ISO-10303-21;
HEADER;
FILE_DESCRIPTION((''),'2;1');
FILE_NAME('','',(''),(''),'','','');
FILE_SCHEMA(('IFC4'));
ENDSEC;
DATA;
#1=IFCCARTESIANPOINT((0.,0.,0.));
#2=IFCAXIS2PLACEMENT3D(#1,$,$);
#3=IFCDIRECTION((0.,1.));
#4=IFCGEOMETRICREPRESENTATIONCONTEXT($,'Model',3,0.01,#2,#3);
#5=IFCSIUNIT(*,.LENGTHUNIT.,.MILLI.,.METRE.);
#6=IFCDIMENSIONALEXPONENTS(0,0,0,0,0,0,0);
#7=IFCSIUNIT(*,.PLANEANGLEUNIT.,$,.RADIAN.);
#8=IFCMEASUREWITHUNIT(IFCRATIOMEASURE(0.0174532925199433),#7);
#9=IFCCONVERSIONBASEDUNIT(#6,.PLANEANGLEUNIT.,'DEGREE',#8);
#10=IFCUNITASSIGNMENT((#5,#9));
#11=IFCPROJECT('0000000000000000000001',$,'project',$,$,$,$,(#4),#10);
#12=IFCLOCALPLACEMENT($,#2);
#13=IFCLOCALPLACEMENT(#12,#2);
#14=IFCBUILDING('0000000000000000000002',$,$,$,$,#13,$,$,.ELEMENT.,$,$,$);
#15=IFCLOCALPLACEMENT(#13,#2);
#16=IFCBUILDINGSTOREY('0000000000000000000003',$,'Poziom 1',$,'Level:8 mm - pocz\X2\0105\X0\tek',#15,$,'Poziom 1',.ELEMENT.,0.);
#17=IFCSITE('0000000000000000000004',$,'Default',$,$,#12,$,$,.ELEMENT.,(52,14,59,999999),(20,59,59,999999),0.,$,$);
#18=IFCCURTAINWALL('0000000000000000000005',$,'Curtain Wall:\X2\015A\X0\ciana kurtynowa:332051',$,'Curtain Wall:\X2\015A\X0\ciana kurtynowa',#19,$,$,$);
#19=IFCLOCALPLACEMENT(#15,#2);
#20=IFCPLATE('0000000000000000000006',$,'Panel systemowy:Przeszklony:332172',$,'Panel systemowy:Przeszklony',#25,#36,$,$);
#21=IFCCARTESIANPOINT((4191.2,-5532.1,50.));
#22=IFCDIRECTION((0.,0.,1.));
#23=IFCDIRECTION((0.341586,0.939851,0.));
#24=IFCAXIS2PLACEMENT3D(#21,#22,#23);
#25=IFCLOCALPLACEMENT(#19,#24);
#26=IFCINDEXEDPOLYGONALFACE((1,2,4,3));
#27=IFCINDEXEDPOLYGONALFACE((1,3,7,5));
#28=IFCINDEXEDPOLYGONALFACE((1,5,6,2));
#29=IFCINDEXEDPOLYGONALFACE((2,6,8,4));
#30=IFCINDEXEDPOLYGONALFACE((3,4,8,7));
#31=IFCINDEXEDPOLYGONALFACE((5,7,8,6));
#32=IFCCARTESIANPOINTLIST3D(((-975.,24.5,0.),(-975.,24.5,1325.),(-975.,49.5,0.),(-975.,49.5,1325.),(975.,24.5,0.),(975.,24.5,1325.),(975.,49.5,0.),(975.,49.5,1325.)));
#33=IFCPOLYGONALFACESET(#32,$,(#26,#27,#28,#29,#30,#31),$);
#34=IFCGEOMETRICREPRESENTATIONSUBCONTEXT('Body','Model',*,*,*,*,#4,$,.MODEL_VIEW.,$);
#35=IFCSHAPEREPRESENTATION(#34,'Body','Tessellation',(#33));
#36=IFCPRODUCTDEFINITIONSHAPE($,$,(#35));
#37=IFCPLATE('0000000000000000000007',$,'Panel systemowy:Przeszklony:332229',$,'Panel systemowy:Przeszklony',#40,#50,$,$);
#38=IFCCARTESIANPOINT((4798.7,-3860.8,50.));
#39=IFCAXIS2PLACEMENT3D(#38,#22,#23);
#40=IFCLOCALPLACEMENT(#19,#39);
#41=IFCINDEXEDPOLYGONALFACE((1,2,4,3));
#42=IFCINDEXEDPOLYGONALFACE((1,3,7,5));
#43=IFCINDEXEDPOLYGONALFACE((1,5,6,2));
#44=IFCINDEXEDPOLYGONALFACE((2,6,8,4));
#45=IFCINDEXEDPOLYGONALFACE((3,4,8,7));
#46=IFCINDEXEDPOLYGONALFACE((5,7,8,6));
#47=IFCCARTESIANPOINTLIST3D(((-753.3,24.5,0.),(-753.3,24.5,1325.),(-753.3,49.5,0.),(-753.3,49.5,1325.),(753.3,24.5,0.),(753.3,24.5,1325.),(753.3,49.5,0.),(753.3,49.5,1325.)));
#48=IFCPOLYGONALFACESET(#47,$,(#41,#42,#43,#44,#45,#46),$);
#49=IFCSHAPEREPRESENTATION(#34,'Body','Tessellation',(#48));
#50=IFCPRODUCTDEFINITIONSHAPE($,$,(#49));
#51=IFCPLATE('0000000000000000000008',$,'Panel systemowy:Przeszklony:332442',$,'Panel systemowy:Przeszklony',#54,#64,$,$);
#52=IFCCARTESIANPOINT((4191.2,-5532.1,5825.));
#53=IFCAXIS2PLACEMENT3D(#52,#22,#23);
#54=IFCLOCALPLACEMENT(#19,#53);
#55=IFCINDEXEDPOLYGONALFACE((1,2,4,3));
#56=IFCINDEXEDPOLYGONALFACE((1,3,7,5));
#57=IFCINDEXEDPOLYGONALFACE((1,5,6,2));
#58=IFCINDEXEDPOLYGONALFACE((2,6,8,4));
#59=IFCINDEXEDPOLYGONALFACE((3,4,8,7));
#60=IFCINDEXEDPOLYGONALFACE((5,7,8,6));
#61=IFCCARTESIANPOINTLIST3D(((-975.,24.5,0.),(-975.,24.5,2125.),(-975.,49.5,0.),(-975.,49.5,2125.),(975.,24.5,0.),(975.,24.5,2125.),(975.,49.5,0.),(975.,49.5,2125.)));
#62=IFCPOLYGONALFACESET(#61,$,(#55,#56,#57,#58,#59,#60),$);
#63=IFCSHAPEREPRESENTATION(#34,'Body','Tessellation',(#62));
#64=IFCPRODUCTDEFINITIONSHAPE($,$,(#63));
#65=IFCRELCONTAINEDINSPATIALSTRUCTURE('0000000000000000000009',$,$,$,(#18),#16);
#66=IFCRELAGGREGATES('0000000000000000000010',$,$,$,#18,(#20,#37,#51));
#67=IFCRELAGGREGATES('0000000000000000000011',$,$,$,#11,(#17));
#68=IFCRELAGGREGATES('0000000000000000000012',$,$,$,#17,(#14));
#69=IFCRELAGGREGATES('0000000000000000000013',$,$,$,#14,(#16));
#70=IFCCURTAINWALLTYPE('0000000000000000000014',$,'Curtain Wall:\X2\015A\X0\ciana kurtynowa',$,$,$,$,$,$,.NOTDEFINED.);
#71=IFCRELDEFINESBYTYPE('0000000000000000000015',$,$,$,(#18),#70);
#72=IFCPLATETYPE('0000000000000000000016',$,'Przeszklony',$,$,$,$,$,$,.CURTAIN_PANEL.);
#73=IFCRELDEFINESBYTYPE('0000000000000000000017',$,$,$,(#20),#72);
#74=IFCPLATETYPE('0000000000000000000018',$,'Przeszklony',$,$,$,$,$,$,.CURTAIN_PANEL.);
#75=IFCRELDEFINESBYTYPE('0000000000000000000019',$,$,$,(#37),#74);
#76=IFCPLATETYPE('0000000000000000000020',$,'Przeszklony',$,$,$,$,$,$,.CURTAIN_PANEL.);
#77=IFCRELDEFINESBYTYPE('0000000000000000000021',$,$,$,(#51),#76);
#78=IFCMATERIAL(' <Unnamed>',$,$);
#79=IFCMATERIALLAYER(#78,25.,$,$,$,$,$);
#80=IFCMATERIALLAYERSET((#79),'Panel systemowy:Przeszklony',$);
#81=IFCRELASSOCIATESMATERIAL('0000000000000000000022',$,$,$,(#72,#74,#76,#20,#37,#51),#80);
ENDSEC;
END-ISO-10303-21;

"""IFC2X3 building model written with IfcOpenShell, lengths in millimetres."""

from ifc_helpers import new_model, entity, si_unit, converted_unit, direction, frame, frame_2d, origin, origin_2d_with_axis, place, context, subcontext, project, spatial, rectangle, extrude, source, transform, mapped, material, layer, layer_set, layer_usage, type_object, type_shapes, element, aggregate, save


model = new_model("IFC2X3")

# Units and contexts
model_context = context("Model", 3, precision=0.01, world=origin(), true_north=direction((0.0, 1.0)))
body_context = subcontext(model_context, "Body", "Model", "MODEL_VIEW")
ifc_project = project(units=[si_unit("LENGTHUNIT", "METRE", prefix="MILLI"), converted_unit("PLANEANGLEUNIT", "DEGREE", entity("IfcRatioMeasure", 0.0174532925199433), si_unit("PLANEANGLEUNIT", "RADIAN"), dimensions=[0, 0, 0, 0, 0, 0, 0])], contexts=[model_context])

# Site, building, storey
site_placement = place(None, origin())
site = spatial("IfcSite", under=ifc_project, at=site_placement, Name="Default", CompositionType="ELEMENT", RefLatitude=(52, 14, 59, 999999), RefLongitude=(20, 59, 59, 999999), RefElevation=0.0)
building_placement = place(site_placement, origin())
building = spatial("IfcBuilding", under=site, at=building_placement, CompositionType="ELEMENT")
storey_placement = place(building_placement, origin())
storey = spatial("IfcBuildingStorey", under=building, at=storey_placement, Name="Poziom 1", ObjectType="Level:8 mm - początek", LongName="Poziom 1", CompositionType="ELEMENT", Elevation=0.0)

# Curtain wall, plates
curtain_wall_type = type_object("IfcCurtainWallType", Name="Curtain Wall:Ściana kurtynowa", PredefinedType="NOTDEFINED")
curtain_wall_placement = place(storey_placement, origin())
curtain_wall = element("IfcCurtainWall", 1, at=curtain_wall_placement, inside=storey, type_object=curtain_wall_type, Name="Curtain Wall:Ściana kurtynowa:332051", ObjectType="Curtain Wall:Ściana kurtynowa")
ifc_material_1 = material(Name=" <Unnamed>")
ifc_layer_1 = layer(ifc_material_1, 25.0)
ifc_layer_set_1 = layer_set([ifc_layer_1], Name="Panel systemowy:Przeszklony")
ifc_layer_usage_1 = layer_usage(ifc_layer_set_1, "AXIS3", "POSITIVE", 0.1)
plate_type_1 = type_object("IfcPlateType", Name="Przeszklony", PredefinedType="CURTAIN_PANEL", material=ifc_layer_set_1)
shared_shape_1 = source(origin(), body_context, "Body", "SweptSolid", [
    extrude(rectangle(XDim=25.0, YDim=1950.0, at=origin_2d_with_axis()), frame((0.0, 37.0, 0.0), z_axis=(0.0, 0.0, 1.0), x_axis=(0.0, 1.0, 0.0)), (0.0, 0.0, 1.0), 1325.0),
])
type_shapes(plate_type_1, [shared_shape_1])
plate_1_placement = place(curtain_wall_placement, frame((4191.2, -5532.1, 50.0), z_axis=(0.0, 0.0, 1.0), x_axis=(0.341586, 0.939851, 0.0)))
plate_1 = element("IfcPlate", 2, at=plate_1_placement, type_object=plate_type_1, material=ifc_layer_usage_1, Name="Panel systemowy:Przeszklony:332172", ObjectType="Panel systemowy:Przeszklony", context=body_context, shape_type="MappedRepresentation", body=[
    mapped(shared_shape_1, transform((0.0, 0.0, 0.0), scale=1.0)),
])
ifc_layer_usage_2 = layer_usage(ifc_layer_set_1, "AXIS3", "POSITIVE", 0.1)
plate_type_2 = type_object("IfcPlateType", Name="Przeszklony", PredefinedType="CURTAIN_PANEL", material=ifc_layer_set_1)
shared_shape_2 = source(origin(), body_context, "Body", "SweptSolid", [
    extrude(rectangle(XDim=25.0, YDim=1506.6, at=origin_2d_with_axis()), frame((0.0, 37.0, 0.0), z_axis=(0.0, 0.0, 1.0), x_axis=(0.0, 1.0, 0.0)), (0.0, 0.0, 1.0), 1325.0),
])
type_shapes(plate_type_2, [shared_shape_2])
plate_2_placement = place(curtain_wall_placement, frame((4798.7, -3860.8, 50.0), z_axis=(0.0, 0.0, 1.0), x_axis=(0.341586, 0.939851, 0.0)))
plate_2 = element("IfcPlate", 3, at=plate_2_placement, type_object=plate_type_2, material=ifc_layer_usage_2, Name="Panel systemowy:Przeszklony:332229", ObjectType="Panel systemowy:Przeszklony", context=body_context, shape_type="MappedRepresentation", body=[
    mapped(shared_shape_2, transform((0.0, 0.0, 0.0), scale=1.0)),
])
ifc_layer_usage_3 = layer_usage(ifc_layer_set_1, "AXIS3", "POSITIVE", 0.1)
plate_type_3 = type_object("IfcPlateType", Name="Przeszklony", PredefinedType="CURTAIN_PANEL", material=ifc_layer_set_1)
shared_shape_3 = source(origin(), body_context, "Body", "SweptSolid", [
    extrude(rectangle(XDim=25.0, YDim=1950.0, at=frame_2d((0.0, 0.0), x_axis=(1.0, 0.0))), frame((0.0, 37.0, 0.0), z_axis=(0.0, 0.0, 1.0), x_axis=(0.0, 1.0, 0.0)), (0.0, 0.0, 1.0), 2125.0),
])
type_shapes(plate_type_3, [shared_shape_3])
plate_3_placement = place(curtain_wall_placement, frame((4191.2, -5532.1, 5825.0), z_axis=(0.0, 0.0, 1.0), x_axis=(0.341586, 0.939851, 0.0)))
plate_3 = element("IfcPlate", 4, at=plate_3_placement, type_object=plate_type_3, material=ifc_layer_usage_3, Name="Panel systemowy:Przeszklony:332442", ObjectType="Panel systemowy:Przeszklony", context=body_context, shape_type="MappedRepresentation", body=[
    mapped(shared_shape_3, transform((0.0, 0.0, 0.0), scale=1.0)),
])
aggregate(curtain_wall, [plate_1, plate_2, plate_3])

save(model, "model.ifc")
